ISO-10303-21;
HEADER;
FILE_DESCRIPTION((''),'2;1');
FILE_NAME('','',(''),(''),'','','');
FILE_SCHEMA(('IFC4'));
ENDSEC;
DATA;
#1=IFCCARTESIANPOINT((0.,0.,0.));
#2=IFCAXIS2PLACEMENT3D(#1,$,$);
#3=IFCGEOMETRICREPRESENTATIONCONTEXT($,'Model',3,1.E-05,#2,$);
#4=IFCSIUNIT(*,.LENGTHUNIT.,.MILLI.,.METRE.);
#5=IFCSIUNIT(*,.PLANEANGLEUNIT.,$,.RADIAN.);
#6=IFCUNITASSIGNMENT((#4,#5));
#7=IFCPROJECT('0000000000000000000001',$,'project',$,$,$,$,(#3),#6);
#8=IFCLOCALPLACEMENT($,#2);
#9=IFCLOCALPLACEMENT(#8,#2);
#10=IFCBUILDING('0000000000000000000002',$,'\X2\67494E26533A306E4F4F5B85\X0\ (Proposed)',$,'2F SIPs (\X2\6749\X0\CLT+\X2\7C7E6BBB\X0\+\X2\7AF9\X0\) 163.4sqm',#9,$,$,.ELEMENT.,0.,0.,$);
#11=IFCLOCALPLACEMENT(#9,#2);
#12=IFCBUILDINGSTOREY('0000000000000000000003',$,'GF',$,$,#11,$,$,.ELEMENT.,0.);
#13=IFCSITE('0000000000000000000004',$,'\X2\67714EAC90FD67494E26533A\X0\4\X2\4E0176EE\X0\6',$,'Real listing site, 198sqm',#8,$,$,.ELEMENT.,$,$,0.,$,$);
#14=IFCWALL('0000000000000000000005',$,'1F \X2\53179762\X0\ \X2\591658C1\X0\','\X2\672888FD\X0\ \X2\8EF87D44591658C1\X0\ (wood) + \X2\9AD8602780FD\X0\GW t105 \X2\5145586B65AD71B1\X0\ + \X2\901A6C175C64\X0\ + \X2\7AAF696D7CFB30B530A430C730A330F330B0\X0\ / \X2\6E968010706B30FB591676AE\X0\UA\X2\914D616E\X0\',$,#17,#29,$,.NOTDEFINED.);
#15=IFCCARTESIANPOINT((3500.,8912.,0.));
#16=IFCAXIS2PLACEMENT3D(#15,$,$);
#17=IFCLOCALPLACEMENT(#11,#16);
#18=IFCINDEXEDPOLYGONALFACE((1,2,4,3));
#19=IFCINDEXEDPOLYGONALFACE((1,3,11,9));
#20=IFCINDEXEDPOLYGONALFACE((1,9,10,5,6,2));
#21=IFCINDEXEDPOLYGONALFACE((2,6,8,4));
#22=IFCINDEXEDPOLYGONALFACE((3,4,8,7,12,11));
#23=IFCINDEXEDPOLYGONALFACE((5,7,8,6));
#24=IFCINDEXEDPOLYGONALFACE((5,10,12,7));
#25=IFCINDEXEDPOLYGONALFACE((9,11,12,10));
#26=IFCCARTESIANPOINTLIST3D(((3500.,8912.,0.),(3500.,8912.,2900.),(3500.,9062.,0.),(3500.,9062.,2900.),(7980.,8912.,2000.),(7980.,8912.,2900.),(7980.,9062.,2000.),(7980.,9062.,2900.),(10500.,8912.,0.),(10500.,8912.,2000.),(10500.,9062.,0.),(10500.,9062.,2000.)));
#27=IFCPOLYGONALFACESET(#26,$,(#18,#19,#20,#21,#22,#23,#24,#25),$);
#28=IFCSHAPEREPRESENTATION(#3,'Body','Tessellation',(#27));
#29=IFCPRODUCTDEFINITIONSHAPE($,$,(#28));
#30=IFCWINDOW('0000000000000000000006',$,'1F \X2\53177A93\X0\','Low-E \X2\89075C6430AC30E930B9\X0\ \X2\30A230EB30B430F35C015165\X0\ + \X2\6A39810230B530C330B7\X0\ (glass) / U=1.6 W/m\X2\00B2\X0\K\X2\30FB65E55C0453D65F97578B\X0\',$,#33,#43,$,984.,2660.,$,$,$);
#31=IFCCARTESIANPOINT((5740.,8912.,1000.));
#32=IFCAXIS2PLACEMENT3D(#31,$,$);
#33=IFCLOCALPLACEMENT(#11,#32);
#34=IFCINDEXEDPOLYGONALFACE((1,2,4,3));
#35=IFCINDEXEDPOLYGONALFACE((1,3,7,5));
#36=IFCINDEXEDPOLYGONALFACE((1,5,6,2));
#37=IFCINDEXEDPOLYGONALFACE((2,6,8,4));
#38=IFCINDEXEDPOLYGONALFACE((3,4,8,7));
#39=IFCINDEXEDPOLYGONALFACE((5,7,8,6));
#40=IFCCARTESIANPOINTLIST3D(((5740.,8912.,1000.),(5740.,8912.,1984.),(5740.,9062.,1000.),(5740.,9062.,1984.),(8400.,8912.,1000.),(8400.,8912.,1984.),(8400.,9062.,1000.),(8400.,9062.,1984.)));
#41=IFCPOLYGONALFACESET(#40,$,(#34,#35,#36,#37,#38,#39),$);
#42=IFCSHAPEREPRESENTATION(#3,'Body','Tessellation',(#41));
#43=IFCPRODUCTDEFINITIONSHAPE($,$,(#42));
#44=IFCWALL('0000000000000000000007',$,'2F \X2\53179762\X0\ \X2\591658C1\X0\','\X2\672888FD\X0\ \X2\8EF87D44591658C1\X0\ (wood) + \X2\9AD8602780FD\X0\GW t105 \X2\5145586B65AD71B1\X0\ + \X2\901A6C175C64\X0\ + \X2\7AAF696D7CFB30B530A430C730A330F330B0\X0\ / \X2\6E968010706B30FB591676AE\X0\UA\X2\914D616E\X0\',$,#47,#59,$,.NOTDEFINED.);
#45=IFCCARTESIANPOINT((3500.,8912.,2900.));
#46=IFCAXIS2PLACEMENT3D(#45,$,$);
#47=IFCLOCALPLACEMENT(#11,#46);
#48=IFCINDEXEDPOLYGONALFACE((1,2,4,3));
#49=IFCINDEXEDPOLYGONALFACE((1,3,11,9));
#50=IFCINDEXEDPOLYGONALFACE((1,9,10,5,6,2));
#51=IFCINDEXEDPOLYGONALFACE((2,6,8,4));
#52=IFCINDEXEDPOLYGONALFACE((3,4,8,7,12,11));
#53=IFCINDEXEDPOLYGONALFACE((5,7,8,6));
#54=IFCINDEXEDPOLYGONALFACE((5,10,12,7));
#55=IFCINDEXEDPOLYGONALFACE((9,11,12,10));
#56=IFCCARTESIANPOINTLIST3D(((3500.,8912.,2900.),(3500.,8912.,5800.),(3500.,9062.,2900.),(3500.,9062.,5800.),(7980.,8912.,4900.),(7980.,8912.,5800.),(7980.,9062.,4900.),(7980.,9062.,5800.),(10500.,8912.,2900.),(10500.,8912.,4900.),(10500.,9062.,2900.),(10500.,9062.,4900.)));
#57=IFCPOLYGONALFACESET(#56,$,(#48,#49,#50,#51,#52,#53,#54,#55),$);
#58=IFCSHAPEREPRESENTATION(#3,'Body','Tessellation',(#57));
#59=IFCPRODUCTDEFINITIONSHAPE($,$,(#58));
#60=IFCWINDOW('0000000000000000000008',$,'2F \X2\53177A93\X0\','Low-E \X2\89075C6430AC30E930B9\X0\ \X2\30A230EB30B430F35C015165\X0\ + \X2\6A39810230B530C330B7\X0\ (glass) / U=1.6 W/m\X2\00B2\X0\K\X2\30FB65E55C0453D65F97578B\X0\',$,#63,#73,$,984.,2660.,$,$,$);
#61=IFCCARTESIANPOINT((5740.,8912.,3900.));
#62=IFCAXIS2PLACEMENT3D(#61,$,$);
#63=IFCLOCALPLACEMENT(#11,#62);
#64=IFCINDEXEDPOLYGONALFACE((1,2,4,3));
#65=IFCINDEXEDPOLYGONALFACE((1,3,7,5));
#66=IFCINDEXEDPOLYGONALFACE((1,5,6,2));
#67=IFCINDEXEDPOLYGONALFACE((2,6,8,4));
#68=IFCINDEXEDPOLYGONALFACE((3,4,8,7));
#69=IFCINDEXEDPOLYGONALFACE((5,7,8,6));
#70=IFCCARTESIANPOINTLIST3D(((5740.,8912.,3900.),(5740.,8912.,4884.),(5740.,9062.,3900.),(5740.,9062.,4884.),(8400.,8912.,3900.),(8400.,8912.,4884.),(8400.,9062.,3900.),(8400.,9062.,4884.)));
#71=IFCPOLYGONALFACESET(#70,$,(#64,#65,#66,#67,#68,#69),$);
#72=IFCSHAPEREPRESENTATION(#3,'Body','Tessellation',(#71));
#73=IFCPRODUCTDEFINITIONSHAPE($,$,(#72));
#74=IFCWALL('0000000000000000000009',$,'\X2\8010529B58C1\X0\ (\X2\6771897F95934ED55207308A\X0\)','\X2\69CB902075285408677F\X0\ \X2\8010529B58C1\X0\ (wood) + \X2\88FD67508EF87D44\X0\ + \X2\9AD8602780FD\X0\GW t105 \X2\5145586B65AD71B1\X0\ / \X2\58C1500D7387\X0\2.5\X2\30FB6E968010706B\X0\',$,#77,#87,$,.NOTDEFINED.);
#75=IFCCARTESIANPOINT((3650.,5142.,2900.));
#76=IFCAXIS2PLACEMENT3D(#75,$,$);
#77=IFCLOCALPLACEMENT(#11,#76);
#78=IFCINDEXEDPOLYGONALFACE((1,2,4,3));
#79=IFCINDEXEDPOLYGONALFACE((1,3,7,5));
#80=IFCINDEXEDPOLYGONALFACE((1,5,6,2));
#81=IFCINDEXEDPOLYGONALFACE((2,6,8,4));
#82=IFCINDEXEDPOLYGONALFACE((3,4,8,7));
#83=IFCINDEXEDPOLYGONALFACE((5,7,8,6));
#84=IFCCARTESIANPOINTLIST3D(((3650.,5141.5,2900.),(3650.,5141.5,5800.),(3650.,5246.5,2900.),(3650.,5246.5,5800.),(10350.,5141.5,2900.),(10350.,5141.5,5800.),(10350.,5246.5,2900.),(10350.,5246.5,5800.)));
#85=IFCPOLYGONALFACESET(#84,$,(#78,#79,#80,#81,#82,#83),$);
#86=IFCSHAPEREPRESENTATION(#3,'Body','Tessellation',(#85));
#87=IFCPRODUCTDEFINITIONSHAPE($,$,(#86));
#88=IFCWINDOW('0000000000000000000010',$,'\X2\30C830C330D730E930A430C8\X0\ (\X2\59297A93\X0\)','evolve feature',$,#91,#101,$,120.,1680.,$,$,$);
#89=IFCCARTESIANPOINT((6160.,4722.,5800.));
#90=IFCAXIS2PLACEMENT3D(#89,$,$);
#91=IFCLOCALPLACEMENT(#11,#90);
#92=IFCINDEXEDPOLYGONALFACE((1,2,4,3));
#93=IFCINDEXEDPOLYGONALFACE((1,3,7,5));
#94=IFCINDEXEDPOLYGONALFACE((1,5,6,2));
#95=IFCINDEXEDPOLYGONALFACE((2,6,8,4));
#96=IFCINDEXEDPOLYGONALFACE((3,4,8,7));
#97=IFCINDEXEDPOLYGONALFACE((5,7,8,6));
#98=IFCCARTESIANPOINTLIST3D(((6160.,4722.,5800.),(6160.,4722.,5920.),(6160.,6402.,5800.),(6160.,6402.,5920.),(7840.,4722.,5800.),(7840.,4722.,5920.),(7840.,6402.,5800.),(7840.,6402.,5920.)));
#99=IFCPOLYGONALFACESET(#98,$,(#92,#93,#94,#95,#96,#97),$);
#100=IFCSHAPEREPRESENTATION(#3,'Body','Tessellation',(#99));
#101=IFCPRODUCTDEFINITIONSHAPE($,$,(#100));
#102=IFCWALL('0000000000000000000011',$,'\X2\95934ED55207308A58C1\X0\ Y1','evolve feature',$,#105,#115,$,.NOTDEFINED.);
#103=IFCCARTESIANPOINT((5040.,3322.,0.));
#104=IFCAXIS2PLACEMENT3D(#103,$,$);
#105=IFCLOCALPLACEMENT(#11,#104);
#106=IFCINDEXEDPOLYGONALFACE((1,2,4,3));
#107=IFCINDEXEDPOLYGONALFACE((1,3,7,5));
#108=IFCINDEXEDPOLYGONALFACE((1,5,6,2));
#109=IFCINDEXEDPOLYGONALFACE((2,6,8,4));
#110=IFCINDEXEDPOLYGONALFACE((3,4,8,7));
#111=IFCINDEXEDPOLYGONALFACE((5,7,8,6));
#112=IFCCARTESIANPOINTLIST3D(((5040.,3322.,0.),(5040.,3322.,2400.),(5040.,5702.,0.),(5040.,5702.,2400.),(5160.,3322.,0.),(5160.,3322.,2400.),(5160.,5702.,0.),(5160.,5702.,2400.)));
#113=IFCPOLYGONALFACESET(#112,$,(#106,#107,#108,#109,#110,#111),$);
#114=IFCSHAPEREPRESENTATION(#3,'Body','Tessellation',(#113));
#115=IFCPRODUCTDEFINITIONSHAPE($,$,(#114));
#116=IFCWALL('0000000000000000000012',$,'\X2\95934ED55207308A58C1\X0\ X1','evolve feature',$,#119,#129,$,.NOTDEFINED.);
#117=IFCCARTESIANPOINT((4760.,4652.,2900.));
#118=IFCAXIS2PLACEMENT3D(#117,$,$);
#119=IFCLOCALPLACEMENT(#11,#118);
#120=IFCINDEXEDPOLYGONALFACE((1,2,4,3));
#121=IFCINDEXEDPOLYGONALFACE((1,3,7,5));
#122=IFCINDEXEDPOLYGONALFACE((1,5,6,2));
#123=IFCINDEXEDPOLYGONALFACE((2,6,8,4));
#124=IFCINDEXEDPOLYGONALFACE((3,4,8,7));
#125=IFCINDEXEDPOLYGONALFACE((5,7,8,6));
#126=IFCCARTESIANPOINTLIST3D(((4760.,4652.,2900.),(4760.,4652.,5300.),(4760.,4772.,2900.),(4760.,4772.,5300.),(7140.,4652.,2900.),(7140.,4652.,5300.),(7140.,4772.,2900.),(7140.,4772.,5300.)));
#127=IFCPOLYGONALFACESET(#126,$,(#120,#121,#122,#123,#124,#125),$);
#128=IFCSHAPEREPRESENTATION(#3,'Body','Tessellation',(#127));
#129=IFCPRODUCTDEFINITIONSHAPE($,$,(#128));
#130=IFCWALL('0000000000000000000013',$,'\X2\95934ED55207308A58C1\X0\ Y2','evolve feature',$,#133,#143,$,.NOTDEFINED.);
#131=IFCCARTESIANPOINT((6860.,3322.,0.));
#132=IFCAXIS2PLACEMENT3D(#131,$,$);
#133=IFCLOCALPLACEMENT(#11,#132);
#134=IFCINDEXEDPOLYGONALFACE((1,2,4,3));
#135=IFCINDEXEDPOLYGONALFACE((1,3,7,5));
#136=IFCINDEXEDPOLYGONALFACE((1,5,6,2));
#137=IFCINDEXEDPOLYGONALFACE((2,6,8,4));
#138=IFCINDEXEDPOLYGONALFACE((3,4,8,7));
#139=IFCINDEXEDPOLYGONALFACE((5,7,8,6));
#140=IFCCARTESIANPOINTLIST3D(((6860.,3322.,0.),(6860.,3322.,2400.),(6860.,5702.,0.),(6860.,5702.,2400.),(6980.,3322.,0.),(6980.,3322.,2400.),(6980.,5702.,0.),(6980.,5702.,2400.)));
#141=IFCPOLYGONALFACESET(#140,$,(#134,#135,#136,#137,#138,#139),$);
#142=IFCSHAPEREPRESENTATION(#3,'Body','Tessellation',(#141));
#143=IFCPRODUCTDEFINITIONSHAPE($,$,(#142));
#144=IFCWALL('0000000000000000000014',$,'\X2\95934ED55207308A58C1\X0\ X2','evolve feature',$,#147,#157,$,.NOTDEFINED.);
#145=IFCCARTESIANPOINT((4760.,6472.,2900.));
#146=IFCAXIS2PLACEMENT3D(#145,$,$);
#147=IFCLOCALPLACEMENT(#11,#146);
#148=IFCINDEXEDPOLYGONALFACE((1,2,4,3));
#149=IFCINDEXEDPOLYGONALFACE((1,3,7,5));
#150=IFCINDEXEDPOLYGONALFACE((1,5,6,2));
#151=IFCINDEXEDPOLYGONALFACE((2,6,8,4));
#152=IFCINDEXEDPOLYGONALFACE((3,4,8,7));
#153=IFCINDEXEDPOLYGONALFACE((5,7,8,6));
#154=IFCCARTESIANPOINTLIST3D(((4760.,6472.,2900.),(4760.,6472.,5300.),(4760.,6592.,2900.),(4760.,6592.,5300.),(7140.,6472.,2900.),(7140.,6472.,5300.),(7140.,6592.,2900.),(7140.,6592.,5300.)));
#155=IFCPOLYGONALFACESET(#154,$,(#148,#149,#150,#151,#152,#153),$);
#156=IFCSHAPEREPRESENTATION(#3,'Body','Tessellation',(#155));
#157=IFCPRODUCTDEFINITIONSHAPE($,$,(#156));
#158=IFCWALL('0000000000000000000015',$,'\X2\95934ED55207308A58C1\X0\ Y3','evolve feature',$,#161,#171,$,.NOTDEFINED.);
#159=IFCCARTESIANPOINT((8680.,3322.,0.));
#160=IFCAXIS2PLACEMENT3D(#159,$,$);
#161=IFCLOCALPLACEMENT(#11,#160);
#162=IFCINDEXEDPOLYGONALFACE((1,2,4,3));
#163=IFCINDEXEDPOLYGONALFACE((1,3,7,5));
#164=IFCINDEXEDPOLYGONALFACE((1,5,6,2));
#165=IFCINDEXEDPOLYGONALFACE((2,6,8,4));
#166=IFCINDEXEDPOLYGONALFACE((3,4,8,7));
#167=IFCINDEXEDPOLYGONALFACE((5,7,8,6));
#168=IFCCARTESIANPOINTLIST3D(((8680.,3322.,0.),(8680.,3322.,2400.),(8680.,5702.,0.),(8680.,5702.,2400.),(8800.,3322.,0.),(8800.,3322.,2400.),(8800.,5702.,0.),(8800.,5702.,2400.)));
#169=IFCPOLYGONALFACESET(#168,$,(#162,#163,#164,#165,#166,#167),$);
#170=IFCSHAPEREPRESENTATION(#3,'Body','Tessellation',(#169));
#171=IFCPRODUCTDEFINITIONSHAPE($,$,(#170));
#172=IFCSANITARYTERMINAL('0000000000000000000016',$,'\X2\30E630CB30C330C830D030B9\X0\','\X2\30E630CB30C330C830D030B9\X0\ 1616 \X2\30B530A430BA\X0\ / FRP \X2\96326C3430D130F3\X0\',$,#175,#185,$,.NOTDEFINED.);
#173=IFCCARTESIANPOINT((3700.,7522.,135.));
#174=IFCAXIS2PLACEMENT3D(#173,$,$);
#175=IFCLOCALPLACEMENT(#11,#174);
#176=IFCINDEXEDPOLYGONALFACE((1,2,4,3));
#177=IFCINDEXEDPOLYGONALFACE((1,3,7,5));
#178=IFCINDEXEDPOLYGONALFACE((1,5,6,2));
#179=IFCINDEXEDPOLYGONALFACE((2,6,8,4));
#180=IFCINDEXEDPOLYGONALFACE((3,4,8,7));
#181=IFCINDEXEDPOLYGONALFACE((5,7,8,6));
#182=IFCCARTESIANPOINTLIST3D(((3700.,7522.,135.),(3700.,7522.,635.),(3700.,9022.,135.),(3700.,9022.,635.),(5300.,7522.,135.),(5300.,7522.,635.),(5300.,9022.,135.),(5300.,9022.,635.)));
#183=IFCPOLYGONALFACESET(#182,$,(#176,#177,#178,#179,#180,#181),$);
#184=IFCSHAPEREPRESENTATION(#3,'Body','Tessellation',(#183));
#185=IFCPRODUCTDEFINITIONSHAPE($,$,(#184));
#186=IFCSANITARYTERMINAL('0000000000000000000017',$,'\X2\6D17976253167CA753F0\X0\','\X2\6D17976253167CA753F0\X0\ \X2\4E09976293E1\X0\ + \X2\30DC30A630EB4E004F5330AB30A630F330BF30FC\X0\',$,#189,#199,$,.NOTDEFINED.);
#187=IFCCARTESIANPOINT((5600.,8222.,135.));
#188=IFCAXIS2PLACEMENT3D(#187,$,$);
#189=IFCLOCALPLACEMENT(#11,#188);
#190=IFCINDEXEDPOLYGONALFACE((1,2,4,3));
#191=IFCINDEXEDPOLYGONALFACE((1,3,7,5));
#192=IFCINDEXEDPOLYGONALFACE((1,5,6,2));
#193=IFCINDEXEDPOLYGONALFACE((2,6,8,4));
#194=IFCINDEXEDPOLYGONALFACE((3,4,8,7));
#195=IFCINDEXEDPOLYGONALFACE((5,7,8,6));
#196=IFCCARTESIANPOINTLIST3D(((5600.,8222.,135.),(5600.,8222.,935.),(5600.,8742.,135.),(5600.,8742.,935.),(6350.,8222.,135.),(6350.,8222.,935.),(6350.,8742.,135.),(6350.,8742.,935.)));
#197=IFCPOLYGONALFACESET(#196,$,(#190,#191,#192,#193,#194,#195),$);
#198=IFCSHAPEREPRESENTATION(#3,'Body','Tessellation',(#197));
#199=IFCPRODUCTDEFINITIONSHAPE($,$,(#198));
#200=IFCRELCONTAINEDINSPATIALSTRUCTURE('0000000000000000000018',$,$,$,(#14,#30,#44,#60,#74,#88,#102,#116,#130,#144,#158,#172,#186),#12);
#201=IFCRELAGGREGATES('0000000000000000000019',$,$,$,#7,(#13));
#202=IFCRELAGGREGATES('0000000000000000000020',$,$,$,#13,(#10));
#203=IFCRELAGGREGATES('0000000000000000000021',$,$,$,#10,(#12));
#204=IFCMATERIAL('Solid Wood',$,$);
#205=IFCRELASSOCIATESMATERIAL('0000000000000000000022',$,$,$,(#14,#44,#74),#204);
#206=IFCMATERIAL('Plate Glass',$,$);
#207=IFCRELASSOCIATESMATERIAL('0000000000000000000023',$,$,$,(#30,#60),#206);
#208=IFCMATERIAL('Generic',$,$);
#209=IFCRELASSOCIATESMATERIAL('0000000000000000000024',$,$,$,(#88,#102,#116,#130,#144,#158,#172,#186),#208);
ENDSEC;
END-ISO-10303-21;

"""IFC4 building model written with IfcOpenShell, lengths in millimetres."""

from ifc_helpers import new_model, si_unit, frame, frame_2d, origin, place, context, project, spatial, rectangle, extrude, material, element, fill, save


model = new_model("IFC4")

# Units and contexts
model_context = context("Model", 3, precision=1e-05, world=origin())
ifc_project = project(units=[si_unit("LENGTHUNIT", "METRE", prefix="MILLI"), si_unit("PLANEANGLEUNIT", "RADIAN")], contexts=[model_context])

# Site, building, storey
site_placement = place(None, origin())
site = spatial("IfcSite", under=ifc_project, at=site_placement, Name="東京都杉並区4丁目6", ObjectType="Real listing site, 198sqm", CompositionType="ELEMENT", RefElevation=0.0)
building_placement = place(site_placement, origin())
building = spatial("IfcBuilding", under=site, at=building_placement, Name="杉並区の住宅 (Proposed)", ObjectType="2F SIPs (杉CLT+籾殻+竹) 163.4sqm", CompositionType="ELEMENT", ElevationOfRefHeight=0.0, ElevationOfTerrain=0.0)
storey_placement = place(building_placement, origin())
storey = spatial("IfcBuildingStorey", under=building, at=storey_placement, Name="GF", CompositionType="ELEMENT", Elevation=0.0)

# Wall, opening, window
ifc_material_1 = material(Name="Solid Wood")
wall_1_placement = place(storey_placement, frame((3500.0, 8912.0, 0.0)))
wall_1 = element("IfcWall", 1, at=wall_1_placement, inside=storey, material=ifc_material_1, Name="1F 北面 外壁", Description="木製 軸組外壁 (wood) + 高性能GW t105 充填断熱 + 通気層 + 窯業系サイディング / 準耐火・外皮UA配慮", PredefinedType="NOTDEFINED", context=model_context, shape_type="SweptSolid", body=[
    extrude(rectangle(XDim=7000.0, YDim=150.0, at=frame_2d((3500.0, 75.0))), frame((3500.0, 8912.0, 0.0)), (0.0, 0.0, 1.0), 2900.0),
])
opening_1_placement = place(storey_placement, frame((5740.0, 8912.0, 1000.0)))
opening_1 = element("IfcOpeningElement", 2, at=opening_1_placement, cuts=wall_1, PredefinedType="NOTDEFINED", context=model_context, shape_type="SweptSolid", body=[
    extrude(rectangle(XDim=2660.0, YDim=150.0, at=frame_2d((1330.0, 75.0))), frame((5740.0, 8912.0, 1000.0)), (0.0, 0.0, 1.0), 984.0),
])
ifc_material_2 = material(Name="Plate Glass")
window_1_placement = place(storey_placement, frame((5740.0, 8912.0, 1000.0)))
window_1 = element("IfcWindow", 3, at=window_1_placement, inside=storey, material=ifc_material_2, Name="1F 北窓", Description="Low-E 複層ガラス アルゴン封入 + 樹脂サッシ (glass) / U=1.6 W/m²K・日射取得型", OverallHeight=984.0, OverallWidth=2660.0, context=model_context, shape_type="SweptSolid", body=[
    extrude(rectangle(XDim=2660.0, YDim=150.0, at=frame_2d((1330.0, 75.0))), frame((5740.0, 8912.0, 1000.0)), (0.0, 0.0, 1.0), 984.0),
])
fill(opening_1, window_1)

# Wall, opening, window
wall_2_placement = place(storey_placement, frame((3500.0, 8912.0, 2900.0)))
wall_2 = element("IfcWall", 4, at=wall_2_placement, inside=storey, material=ifc_material_1, Name="2F 北面 外壁", Description="木製 軸組外壁 (wood) + 高性能GW t105 充填断熱 + 通気層 + 窯業系サイディング / 準耐火・外皮UA配慮", PredefinedType="NOTDEFINED", context=model_context, shape_type="SweptSolid", body=[
    extrude(rectangle(XDim=7000.0, YDim=150.0, at=frame_2d((3500.0, 75.0))), frame((3500.0, 8912.0, 2900.0)), (0.0, 0.0, 1.0), 2900.0),
])
opening_2_placement = place(storey_placement, frame((5740.0, 8912.0, 3900.0)))
opening_2 = element("IfcOpeningElement", 5, at=opening_2_placement, cuts=wall_2, PredefinedType="NOTDEFINED", context=model_context, shape_type="SweptSolid", body=[
    extrude(rectangle(XDim=2660.0, YDim=150.0, at=frame_2d((1330.0, 75.0))), frame((5740.0, 8912.0, 3900.0)), (0.0, 0.0, 1.0), 984.0),
])
window_2_placement = place(storey_placement, frame((5740.0, 8912.0, 3900.0)))
window_2 = element("IfcWindow", 6, at=window_2_placement, inside=storey, material=ifc_material_2, Name="2F 北窓", Description="Low-E 複層ガラス アルゴン封入 + 樹脂サッシ (glass) / U=1.6 W/m²K・日射取得型", OverallHeight=984.0, OverallWidth=2660.0, context=model_context, shape_type="SweptSolid", body=[
    extrude(rectangle(XDim=2660.0, YDim=150.0, at=frame_2d((1330.0, 75.0))), frame((5740.0, 8912.0, 3900.0)), (0.0, 0.0, 1.0), 984.0),
])
fill(opening_2, window_2)

# Wall
wall_3_placement = place(storey_placement, frame((3650.0, 5142.0, 2900.0)))
element("IfcWall", 7, at=wall_3_placement, inside=storey, material=ifc_material_1, Name="耐力壁 (東西間仕切り)", Description="構造用合板 耐力壁 (wood) + 製材軸組 + 高性能GW t105 充填断熱 / 壁倍率2.5・準耐火", PredefinedType="NOTDEFINED", context=model_context, shape_type="SweptSolid", body=[
    extrude(rectangle(XDim=6700.0, YDim=105.0, at=frame_2d((3350.0, 52.0))), frame((3650.0, 5142.0, 2900.0)), (0.0, 0.0, 1.0), 2900.0),
])

# Window
ifc_material_3 = material(Name="Generic")
window_3_placement = place(storey_placement, frame((6160.0, 4722.0, 5800.0)))
element("IfcWindow", 8, at=window_3_placement, inside=storey, material=ifc_material_3, Name="トップライト (天窓)", Description="evolve feature", OverallHeight=120.0, OverallWidth=1680.0, context=model_context, shape_type="SweptSolid", body=[
    extrude(rectangle(XDim=1680.0, YDim=1680.0, at=frame_2d((840.0, 840.0))), frame((6160.0, 4722.0, 5800.0)), (0.0, 0.0, 1.0), 120.0),
])

# Walls
wall_4_placement = place(storey_placement, frame((5040.0, 3322.0, 0.0)))
element("IfcWall", 9, at=wall_4_placement, inside=storey, material=ifc_material_3, Name="間仕切り壁 Y1", Description="evolve feature", PredefinedType="NOTDEFINED", context=model_context, shape_type="SweptSolid", body=[
    extrude(rectangle(XDim=120.0, YDim=2380.0, at=frame_2d((60.0, 1190.0))), frame((5040.0, 3322.0, 0.0)), (0.0, 0.0, 1.0), 2400.0),
])
wall_5_placement = place(storey_placement, frame((4760.0, 4652.0, 2900.0)))
element("IfcWall", 10, at=wall_5_placement, inside=storey, material=ifc_material_3, Name="間仕切り壁 X1", Description="evolve feature", PredefinedType="NOTDEFINED", context=model_context, shape_type="SweptSolid", body=[
    extrude(rectangle(XDim=2380.0, YDim=120.0, at=frame_2d((1190.0, 60.0))), frame((4760.0, 4652.0, 2900.0)), (0.0, 0.0, 1.0), 2400.0),
])
wall_6_placement = place(storey_placement, frame((6860.0, 3322.0, 0.0)))
element("IfcWall", 11, at=wall_6_placement, inside=storey, material=ifc_material_3, Name="間仕切り壁 Y2", Description="evolve feature", PredefinedType="NOTDEFINED", context=model_context, shape_type="SweptSolid", body=[
    extrude(rectangle(XDim=120.0, YDim=2380.0, at=frame_2d((60.0, 1190.0))), frame((6860.0, 3322.0, 0.0)), (0.0, 0.0, 1.0), 2400.0),
])
wall_7_placement = place(storey_placement, frame((4760.0, 6472.0, 2900.0)))
element("IfcWall", 12, at=wall_7_placement, inside=storey, material=ifc_material_3, Name="間仕切り壁 X2", Description="evolve feature", PredefinedType="NOTDEFINED", context=model_context, shape_type="SweptSolid", body=[
    extrude(rectangle(XDim=2380.0, YDim=120.0, at=frame_2d((1190.0, 60.0))), frame((4760.0, 6472.0, 2900.0)), (0.0, 0.0, 1.0), 2400.0),
])
wall_8_placement = place(storey_placement, frame((8680.0, 3322.0, 0.0)))
element("IfcWall", 13, at=wall_8_placement, inside=storey, material=ifc_material_3, Name="間仕切り壁 Y3", Description="evolve feature", PredefinedType="NOTDEFINED", context=model_context, shape_type="SweptSolid", body=[
    extrude(rectangle(XDim=120.0, YDim=2380.0, at=frame_2d((60.0, 1190.0))), frame((8680.0, 3322.0, 0.0)), (0.0, 0.0, 1.0), 2400.0),
])

# Sanitary terminals
sanitary_terminal_1_placement = place(storey_placement, frame((3700.0, 7522.0, 135.0)))
element("IfcSanitaryTerminal", 14, at=sanitary_terminal_1_placement, inside=storey, material=ifc_material_3, Name="ユニットバス", Description="ユニットバス 1616 サイズ / FRP 防水パン", PredefinedType="NOTDEFINED", context=model_context, shape_type="SweptSolid", body=[
    extrude(rectangle(XDim=1600.0, YDim=1500.0, at=frame_2d((800.0, 750.0))), frame((3700.0, 7522.0, 135.0)), (0.0, 0.0, 1.0), 500.0),
])
sanitary_terminal_2_placement = place(storey_placement, frame((5600.0, 8222.0, 135.0)))
element("IfcSanitaryTerminal", 15, at=sanitary_terminal_2_placement, inside=storey, material=ifc_material_3, Name="洗面化粧台", Description="洗面化粧台 三面鏡 + ボウル一体カウンター", PredefinedType="NOTDEFINED", context=model_context, shape_type="SweptSolid", body=[
    extrude(rectangle(XDim=750.0, YDim=520.0, at=frame_2d((375.0, 260.0))), frame((5600.0, 8222.0, 135.0)), (0.0, 0.0, 1.0), 800.0),
])

save(model, "model.ifc")
